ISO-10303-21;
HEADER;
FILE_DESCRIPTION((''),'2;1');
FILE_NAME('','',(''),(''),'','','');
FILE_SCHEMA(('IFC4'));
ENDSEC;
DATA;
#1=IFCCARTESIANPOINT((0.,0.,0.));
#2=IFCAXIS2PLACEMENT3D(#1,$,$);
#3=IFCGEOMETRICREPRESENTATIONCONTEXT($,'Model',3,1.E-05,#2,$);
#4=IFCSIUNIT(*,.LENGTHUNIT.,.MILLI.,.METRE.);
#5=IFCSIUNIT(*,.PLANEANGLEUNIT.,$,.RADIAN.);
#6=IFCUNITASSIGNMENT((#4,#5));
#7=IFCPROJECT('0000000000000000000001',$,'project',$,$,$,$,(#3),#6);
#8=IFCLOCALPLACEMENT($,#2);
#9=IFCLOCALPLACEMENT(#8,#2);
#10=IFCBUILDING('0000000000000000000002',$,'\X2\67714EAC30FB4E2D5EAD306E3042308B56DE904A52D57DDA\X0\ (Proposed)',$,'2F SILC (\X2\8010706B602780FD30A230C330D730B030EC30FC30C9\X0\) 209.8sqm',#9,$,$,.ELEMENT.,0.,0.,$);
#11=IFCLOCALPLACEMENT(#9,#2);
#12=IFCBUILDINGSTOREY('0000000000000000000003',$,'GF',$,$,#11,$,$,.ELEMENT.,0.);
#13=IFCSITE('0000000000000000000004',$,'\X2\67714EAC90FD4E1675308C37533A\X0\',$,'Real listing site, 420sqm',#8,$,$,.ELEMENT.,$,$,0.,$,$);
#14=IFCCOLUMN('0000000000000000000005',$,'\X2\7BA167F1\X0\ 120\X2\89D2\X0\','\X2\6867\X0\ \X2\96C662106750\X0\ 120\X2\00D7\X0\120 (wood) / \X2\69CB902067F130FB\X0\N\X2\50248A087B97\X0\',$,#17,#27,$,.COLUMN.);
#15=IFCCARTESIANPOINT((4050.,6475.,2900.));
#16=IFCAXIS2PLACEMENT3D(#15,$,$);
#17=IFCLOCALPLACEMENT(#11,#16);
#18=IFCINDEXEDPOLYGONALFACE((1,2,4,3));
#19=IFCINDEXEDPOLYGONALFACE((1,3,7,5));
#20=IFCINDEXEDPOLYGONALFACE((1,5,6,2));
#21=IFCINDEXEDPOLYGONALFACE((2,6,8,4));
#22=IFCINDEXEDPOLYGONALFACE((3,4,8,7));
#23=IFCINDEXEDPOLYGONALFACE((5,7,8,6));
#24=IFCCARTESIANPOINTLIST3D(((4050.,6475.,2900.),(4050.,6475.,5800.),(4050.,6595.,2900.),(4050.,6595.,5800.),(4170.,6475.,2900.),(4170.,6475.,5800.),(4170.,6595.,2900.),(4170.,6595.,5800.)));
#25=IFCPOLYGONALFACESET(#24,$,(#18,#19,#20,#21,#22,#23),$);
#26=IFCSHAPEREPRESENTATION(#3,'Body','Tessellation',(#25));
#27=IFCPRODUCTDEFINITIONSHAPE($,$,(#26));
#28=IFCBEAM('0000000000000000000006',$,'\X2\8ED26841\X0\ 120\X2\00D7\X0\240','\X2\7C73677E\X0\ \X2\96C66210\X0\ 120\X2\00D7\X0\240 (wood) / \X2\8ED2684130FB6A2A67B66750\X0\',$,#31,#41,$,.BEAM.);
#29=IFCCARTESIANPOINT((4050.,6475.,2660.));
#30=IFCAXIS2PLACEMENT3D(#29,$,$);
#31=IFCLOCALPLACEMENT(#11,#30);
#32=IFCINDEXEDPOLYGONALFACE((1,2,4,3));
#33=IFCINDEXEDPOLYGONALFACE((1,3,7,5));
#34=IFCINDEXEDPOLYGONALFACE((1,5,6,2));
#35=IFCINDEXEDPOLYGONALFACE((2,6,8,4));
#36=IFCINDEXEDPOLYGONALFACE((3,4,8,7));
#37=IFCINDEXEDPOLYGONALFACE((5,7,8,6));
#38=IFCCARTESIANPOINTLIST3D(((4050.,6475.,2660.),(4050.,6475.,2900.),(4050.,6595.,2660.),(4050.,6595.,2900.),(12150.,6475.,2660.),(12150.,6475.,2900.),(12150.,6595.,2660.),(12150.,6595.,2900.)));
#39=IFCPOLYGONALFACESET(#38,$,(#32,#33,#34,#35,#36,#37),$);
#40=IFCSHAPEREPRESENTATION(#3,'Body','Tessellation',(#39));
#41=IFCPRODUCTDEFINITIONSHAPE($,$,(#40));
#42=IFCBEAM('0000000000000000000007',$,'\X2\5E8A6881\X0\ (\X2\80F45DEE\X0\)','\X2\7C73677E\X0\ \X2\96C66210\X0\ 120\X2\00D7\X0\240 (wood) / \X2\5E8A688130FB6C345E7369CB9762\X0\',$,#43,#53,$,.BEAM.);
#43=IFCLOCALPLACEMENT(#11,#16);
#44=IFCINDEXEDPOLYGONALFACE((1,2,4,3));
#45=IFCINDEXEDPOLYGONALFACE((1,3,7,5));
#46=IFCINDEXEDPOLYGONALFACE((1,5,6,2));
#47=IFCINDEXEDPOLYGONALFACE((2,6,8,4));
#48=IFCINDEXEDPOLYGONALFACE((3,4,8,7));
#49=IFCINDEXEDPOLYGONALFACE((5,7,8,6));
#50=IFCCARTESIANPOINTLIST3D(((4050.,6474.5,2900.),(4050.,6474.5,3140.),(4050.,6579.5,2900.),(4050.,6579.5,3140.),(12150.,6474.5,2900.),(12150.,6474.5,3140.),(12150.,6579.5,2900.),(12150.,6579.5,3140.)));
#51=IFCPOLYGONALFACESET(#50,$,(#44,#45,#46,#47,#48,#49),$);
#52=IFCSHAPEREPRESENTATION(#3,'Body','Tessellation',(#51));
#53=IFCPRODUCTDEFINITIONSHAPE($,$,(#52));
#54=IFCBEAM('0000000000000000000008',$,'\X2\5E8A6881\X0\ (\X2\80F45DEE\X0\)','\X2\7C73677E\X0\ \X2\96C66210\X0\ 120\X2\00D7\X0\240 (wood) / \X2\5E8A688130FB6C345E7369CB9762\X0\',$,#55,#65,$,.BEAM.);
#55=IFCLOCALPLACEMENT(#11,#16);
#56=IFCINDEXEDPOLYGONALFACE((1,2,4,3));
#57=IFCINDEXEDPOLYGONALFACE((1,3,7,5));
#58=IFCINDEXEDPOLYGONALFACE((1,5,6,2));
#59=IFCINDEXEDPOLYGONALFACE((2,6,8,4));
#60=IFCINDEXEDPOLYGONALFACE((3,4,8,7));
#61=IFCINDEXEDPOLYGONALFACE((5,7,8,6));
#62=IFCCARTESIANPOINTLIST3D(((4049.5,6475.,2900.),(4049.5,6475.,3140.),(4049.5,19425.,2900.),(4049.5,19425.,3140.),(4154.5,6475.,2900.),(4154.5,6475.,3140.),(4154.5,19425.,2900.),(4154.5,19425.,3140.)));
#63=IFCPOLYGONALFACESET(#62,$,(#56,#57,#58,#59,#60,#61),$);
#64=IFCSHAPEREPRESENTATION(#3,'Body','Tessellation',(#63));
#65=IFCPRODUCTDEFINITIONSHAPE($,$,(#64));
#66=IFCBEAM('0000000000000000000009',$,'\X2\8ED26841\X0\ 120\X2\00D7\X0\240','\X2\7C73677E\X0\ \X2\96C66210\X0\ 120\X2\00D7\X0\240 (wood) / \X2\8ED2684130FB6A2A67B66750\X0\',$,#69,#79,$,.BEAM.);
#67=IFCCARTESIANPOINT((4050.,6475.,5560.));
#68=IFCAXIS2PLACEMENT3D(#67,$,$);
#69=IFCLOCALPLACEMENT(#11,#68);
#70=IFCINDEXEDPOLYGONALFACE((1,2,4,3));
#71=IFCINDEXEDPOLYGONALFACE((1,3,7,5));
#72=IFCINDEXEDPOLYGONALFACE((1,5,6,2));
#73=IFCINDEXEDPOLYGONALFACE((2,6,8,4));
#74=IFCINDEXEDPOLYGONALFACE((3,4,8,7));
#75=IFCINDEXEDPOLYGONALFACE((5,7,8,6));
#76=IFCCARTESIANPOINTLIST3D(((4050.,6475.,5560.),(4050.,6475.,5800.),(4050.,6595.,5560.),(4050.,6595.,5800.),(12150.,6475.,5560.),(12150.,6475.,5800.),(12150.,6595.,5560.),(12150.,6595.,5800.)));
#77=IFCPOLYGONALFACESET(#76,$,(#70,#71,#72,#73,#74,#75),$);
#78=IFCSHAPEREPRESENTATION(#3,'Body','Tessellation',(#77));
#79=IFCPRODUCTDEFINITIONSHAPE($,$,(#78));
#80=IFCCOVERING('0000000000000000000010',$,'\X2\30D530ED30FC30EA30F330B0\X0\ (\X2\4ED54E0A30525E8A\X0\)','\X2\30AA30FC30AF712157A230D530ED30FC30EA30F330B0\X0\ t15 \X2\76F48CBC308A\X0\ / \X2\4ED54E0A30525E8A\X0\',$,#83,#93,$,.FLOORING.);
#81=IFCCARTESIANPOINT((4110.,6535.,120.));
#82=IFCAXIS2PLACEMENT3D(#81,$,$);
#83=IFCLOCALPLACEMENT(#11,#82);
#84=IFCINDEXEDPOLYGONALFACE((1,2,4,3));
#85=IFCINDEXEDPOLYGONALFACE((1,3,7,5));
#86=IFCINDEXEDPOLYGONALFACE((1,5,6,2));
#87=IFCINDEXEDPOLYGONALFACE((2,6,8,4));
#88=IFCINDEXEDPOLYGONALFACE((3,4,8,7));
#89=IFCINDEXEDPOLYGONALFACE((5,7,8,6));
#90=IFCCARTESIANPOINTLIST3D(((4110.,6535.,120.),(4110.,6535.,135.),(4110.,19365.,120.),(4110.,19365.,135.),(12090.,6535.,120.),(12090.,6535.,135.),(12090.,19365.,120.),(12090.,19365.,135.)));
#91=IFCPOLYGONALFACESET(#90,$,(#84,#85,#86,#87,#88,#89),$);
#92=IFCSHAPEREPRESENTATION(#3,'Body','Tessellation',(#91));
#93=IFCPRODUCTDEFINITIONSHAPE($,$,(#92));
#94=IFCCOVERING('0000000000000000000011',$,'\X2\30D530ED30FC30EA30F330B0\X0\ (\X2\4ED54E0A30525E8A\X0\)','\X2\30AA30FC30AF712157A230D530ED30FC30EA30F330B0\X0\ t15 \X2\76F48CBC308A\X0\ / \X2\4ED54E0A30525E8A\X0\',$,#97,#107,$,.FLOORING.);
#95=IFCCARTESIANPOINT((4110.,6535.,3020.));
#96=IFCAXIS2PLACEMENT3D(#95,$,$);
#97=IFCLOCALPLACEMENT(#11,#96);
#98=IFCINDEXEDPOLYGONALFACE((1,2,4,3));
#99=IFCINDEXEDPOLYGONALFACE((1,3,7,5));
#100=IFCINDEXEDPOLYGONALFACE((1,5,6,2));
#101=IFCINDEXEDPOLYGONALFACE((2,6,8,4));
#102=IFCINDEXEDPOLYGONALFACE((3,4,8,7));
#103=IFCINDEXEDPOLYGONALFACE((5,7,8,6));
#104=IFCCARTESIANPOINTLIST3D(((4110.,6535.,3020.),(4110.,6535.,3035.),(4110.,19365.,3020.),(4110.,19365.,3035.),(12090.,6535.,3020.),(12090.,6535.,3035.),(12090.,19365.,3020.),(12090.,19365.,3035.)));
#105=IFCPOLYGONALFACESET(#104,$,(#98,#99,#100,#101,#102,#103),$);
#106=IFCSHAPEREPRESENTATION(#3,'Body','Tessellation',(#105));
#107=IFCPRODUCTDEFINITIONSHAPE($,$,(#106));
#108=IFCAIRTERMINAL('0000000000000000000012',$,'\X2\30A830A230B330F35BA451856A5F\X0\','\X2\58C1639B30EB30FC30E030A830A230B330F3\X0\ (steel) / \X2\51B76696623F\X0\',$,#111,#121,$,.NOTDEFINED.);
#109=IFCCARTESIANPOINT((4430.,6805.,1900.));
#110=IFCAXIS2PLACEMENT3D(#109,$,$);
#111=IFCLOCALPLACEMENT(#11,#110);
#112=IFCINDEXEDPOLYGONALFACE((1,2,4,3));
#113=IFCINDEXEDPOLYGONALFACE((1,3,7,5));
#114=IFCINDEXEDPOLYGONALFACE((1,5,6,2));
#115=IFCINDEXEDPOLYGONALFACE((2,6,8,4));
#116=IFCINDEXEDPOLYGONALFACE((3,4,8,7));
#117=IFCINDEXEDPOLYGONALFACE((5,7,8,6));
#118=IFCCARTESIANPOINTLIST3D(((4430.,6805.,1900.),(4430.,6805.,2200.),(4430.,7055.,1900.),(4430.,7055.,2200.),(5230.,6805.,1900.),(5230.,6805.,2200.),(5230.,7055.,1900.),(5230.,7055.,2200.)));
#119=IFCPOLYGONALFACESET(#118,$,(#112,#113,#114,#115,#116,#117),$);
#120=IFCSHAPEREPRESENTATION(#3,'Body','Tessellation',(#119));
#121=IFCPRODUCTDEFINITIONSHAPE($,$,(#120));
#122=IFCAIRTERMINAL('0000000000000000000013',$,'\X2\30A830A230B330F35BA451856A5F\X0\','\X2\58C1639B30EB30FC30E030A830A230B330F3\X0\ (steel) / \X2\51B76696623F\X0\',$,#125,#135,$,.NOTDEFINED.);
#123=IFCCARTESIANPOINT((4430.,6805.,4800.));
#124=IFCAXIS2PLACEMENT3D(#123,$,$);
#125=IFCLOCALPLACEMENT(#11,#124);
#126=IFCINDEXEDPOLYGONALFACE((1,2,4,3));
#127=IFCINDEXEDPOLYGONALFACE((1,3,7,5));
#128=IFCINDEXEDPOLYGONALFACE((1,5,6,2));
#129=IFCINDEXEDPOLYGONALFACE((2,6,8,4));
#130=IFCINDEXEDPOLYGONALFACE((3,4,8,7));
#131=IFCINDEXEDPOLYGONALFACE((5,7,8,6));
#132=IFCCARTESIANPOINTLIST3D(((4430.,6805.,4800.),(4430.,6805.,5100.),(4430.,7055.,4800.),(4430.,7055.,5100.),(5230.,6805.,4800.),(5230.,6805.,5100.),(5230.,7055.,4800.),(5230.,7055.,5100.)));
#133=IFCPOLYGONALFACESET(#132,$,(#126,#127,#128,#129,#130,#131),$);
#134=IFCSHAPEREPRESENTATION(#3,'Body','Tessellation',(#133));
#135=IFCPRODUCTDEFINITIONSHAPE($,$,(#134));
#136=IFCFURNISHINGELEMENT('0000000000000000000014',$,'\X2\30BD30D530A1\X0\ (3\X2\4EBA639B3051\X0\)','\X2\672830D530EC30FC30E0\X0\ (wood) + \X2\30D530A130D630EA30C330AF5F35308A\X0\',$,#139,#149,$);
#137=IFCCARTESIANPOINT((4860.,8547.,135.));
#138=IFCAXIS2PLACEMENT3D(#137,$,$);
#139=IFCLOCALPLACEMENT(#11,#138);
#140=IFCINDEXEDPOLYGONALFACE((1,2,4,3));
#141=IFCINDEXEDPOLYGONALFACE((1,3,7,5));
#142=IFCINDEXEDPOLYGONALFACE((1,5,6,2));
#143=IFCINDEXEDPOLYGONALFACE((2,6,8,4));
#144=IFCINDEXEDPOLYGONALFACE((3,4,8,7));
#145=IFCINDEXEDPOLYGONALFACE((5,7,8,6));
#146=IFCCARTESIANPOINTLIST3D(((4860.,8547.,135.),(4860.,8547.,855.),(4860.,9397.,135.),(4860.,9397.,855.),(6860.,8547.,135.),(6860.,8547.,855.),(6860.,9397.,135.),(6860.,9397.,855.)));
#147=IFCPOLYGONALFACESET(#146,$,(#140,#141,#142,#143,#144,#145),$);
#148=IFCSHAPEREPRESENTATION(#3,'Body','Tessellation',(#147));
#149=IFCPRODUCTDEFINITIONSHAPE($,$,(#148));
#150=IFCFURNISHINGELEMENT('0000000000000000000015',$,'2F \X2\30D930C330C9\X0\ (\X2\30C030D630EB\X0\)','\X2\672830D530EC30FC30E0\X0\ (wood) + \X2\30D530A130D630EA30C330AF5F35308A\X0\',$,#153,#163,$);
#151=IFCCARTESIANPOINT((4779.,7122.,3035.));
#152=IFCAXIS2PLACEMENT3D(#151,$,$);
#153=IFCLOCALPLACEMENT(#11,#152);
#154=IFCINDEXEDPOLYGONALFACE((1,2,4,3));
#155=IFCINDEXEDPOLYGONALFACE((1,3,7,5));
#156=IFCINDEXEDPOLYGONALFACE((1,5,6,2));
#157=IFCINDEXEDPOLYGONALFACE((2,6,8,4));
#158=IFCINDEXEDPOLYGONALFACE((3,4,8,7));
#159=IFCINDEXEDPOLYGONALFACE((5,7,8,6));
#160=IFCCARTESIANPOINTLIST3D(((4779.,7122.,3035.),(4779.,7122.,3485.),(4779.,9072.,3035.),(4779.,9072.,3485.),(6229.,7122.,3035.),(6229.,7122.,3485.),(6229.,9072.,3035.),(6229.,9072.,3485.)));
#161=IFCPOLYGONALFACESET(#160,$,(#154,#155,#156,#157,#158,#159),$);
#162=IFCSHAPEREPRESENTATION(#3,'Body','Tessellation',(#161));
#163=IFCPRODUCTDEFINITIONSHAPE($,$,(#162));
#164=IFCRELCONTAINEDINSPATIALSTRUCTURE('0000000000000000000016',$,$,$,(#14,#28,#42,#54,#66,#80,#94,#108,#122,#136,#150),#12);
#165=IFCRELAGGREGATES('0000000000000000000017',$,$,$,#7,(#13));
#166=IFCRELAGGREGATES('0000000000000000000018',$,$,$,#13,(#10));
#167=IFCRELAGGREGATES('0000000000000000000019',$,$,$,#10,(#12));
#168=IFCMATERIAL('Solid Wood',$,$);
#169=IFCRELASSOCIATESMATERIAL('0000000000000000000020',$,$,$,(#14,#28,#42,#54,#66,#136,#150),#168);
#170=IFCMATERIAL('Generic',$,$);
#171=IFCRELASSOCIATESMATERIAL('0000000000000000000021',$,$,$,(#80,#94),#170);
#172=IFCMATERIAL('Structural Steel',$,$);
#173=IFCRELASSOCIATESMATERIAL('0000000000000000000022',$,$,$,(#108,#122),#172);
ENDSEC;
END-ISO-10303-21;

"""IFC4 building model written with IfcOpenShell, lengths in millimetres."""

from ifc_helpers import new_model, si_unit, frame, frame_2d, origin, place, context, project, spatial, rectangle, extrude, material, element, save


model = new_model("IFC4")

# Units and contexts
model_context = context("Model", 3, precision=1e-05, world=origin())
ifc_project = project(units=[si_unit("LENGTHUNIT", "METRE", prefix="MILLI"), si_unit("PLANEANGLEUNIT", "RADIAN")], contexts=[model_context])

# Site, building, storey
site_placement = place(None, origin())
site = spatial("IfcSite", under=ifc_project, at=site_placement, Name="東京都世田谷区", ObjectType="Real listing site, 420sqm", CompositionType="ELEMENT", RefElevation=0.0)
building_placement = place(site_placement, origin())
building = spatial("IfcBuilding", under=site, at=building_placement, Name="東京・中庭のある回遊動線 (Proposed)", ObjectType="2F SILC (耐火性能アップグレード) 209.8sqm", CompositionType="ELEMENT", ElevationOfRefHeight=0.0, ElevationOfTerrain=0.0)
storey_placement = place(building_placement, origin())
storey = spatial("IfcBuildingStorey", under=building, at=storey_placement, Name="GF", CompositionType="ELEMENT", Elevation=0.0)

# Column
ifc_material_1 = material(Name="Solid Wood")
column_1_placement = place(storey_placement, frame((4050.0, 6475.0, 2900.0)))
element("IfcColumn", 1, at=column_1_placement, inside=storey, material=ifc_material_1, Name="管柱 120角", Description="桧 集成材 120×120 (wood) / 構造柱・N値計算", PredefinedType="COLUMN", context=model_context, shape_type="SweptSolid", body=[
    extrude(rectangle(XDim=120.0, YDim=120.0, at=frame_2d((60.0, 60.0))), frame((4050.0, 6475.0, 2900.0)), (0.0, 0.0, 1.0), 2900.0),
])

# Beams
beam_1_placement = place(storey_placement, frame((4050.0, 6475.0, 2660.0)))
element("IfcBeam", 2, at=beam_1_placement, inside=storey, material=ifc_material_1, Name="軒桁 120×240", Description="米松 集成 120×240 (wood) / 軒桁・横架材", PredefinedType="BEAM", context=model_context, shape_type="SweptSolid", body=[
    extrude(rectangle(XDim=8100.0, YDim=120.0, at=frame_2d((4050.0, 60.0))), frame((4050.0, 6475.0, 2660.0)), (0.0, 0.0, 1.0), 240.0),
])
beam_2_placement = place(storey_placement, frame((4050.0, 6475.0, 2900.0)))
element("IfcBeam", 3, at=beam_2_placement, inside=storey, material=ifc_material_1, Name="床梁 (胴差)", Description="米松 集成 120×240 (wood) / 床梁・水平構面", PredefinedType="BEAM", context=model_context, shape_type="SweptSolid", body=[
    extrude(rectangle(XDim=8100.0, YDim=105.0, at=frame_2d((4050.0, 52.0))), frame((4050.0, 6475.0, 2900.0)), (0.0, 0.0, 1.0), 240.0),
])
beam_3_placement = place(storey_placement, frame((4050.0, 6475.0, 2900.0)))
element("IfcBeam", 4, at=beam_3_placement, inside=storey, material=ifc_material_1, Name="床梁 (胴差)", Description="米松 集成 120×240 (wood) / 床梁・水平構面", PredefinedType="BEAM", context=model_context, shape_type="SweptSolid", body=[
    extrude(rectangle(XDim=105.0, YDim=12950.0, at=frame_2d((52.0, 6475.0))), frame((4050.0, 6475.0, 2900.0)), (0.0, 0.0, 1.0), 240.0),
])
beam_4_placement = place(storey_placement, frame((4050.0, 6475.0, 5560.0)))
element("IfcBeam", 5, at=beam_4_placement, inside=storey, material=ifc_material_1, Name="軒桁 120×240", Description="米松 集成 120×240 (wood) / 軒桁・横架材", PredefinedType="BEAM", context=model_context, shape_type="SweptSolid", body=[
    extrude(rectangle(XDim=8100.0, YDim=120.0, at=frame_2d((4050.0, 60.0))), frame((4050.0, 6475.0, 5560.0)), (0.0, 0.0, 1.0), 240.0),
])

# Coverings
ifc_material_2 = material(Name="Generic")
covering_1_placement = place(storey_placement, frame((4110.0, 6535.0, 120.0)))
element("IfcCovering", 6, at=covering_1_placement, inside=storey, material=ifc_material_2, Name="フローリング (仕上げ床)", Description="オーク無垢フローリング t15 直貼り / 仕上げ床", PredefinedType="FLOORING", context=model_context, shape_type="SweptSolid", body=[
    extrude(rectangle(XDim=7980.0, YDim=12830.0, at=frame_2d((3990.0, 6415.0))), frame((4110.0, 6535.0, 120.0)), (0.0, 0.0, 1.0), 15.0),
])
covering_2_placement = place(storey_placement, frame((4110.0, 6535.0, 3020.0)))
element("IfcCovering", 7, at=covering_2_placement, inside=storey, material=ifc_material_2, Name="フローリング (仕上げ床)", Description="オーク無垢フローリング t15 直貼り / 仕上げ床", PredefinedType="FLOORING", context=model_context, shape_type="SweptSolid", body=[
    extrude(rectangle(XDim=7980.0, YDim=12830.0, at=frame_2d((3990.0, 6415.0))), frame((4110.0, 6535.0, 3020.0)), (0.0, 0.0, 1.0), 15.0),
])

# Air terminals
ifc_material_3 = material(Name="Structural Steel")
air_terminal_1_placement = place(storey_placement, frame((4430.0, 6805.0, 1900.0)))
element("IfcAirTerminal", 8, at=air_terminal_1_placement, inside=storey, material=ifc_material_3, Name="エアコン室内機", Description="壁掛ルームエアコン (steel) / 冷暖房", PredefinedType="NOTDEFINED", context=model_context, shape_type="SweptSolid", body=[
    extrude(rectangle(XDim=800.0, YDim=250.0, at=frame_2d((400.0, 125.0))), frame((4430.0, 6805.0, 1900.0)), (0.0, 0.0, 1.0), 300.0),
])
air_terminal_2_placement = place(storey_placement, frame((4430.0, 6805.0, 4800.0)))
element("IfcAirTerminal", 9, at=air_terminal_2_placement, inside=storey, material=ifc_material_3, Name="エアコン室内機", Description="壁掛ルームエアコン (steel) / 冷暖房", PredefinedType="NOTDEFINED", context=model_context, shape_type="SweptSolid", body=[
    extrude(rectangle(XDim=800.0, YDim=250.0, at=frame_2d((400.0, 125.0))), frame((4430.0, 6805.0, 4800.0)), (0.0, 0.0, 1.0), 300.0),
])

# Furnishing elements
furnishing_1_placement = place(storey_placement, frame((4860.0, 8547.0, 135.0)))
element("IfcFurnishingElement", 10, at=furnishing_1_placement, inside=storey, material=ifc_material_1, Name="ソファ (3人掛け)", Description="木フレーム (wood) + ファブリック張り", context=model_context, shape_type="SweptSolid", body=[
    extrude(rectangle(XDim=2000.0, YDim=850.0, at=frame_2d((1000.0, 425.0))), frame((4860.0, 8547.0, 135.0)), (0.0, 0.0, 1.0), 720.0),
])
furnishing_2_placement = place(storey_placement, frame((4779.0, 7122.0, 3035.0)))
element("IfcFurnishingElement", 11, at=furnishing_2_placement, inside=storey, material=ifc_material_1, Name="2F ベッド (ダブル)", Description="木フレーム (wood) + ファブリック張り", context=model_context, shape_type="SweptSolid", body=[
    extrude(rectangle(XDim=1450.0, YDim=1950.0, at=frame_2d((725.0, 975.0))), frame((4779.0, 7122.0, 3035.0)), (0.0, 0.0, 1.0), 450.0),
])

save(model, "model.ifc")
